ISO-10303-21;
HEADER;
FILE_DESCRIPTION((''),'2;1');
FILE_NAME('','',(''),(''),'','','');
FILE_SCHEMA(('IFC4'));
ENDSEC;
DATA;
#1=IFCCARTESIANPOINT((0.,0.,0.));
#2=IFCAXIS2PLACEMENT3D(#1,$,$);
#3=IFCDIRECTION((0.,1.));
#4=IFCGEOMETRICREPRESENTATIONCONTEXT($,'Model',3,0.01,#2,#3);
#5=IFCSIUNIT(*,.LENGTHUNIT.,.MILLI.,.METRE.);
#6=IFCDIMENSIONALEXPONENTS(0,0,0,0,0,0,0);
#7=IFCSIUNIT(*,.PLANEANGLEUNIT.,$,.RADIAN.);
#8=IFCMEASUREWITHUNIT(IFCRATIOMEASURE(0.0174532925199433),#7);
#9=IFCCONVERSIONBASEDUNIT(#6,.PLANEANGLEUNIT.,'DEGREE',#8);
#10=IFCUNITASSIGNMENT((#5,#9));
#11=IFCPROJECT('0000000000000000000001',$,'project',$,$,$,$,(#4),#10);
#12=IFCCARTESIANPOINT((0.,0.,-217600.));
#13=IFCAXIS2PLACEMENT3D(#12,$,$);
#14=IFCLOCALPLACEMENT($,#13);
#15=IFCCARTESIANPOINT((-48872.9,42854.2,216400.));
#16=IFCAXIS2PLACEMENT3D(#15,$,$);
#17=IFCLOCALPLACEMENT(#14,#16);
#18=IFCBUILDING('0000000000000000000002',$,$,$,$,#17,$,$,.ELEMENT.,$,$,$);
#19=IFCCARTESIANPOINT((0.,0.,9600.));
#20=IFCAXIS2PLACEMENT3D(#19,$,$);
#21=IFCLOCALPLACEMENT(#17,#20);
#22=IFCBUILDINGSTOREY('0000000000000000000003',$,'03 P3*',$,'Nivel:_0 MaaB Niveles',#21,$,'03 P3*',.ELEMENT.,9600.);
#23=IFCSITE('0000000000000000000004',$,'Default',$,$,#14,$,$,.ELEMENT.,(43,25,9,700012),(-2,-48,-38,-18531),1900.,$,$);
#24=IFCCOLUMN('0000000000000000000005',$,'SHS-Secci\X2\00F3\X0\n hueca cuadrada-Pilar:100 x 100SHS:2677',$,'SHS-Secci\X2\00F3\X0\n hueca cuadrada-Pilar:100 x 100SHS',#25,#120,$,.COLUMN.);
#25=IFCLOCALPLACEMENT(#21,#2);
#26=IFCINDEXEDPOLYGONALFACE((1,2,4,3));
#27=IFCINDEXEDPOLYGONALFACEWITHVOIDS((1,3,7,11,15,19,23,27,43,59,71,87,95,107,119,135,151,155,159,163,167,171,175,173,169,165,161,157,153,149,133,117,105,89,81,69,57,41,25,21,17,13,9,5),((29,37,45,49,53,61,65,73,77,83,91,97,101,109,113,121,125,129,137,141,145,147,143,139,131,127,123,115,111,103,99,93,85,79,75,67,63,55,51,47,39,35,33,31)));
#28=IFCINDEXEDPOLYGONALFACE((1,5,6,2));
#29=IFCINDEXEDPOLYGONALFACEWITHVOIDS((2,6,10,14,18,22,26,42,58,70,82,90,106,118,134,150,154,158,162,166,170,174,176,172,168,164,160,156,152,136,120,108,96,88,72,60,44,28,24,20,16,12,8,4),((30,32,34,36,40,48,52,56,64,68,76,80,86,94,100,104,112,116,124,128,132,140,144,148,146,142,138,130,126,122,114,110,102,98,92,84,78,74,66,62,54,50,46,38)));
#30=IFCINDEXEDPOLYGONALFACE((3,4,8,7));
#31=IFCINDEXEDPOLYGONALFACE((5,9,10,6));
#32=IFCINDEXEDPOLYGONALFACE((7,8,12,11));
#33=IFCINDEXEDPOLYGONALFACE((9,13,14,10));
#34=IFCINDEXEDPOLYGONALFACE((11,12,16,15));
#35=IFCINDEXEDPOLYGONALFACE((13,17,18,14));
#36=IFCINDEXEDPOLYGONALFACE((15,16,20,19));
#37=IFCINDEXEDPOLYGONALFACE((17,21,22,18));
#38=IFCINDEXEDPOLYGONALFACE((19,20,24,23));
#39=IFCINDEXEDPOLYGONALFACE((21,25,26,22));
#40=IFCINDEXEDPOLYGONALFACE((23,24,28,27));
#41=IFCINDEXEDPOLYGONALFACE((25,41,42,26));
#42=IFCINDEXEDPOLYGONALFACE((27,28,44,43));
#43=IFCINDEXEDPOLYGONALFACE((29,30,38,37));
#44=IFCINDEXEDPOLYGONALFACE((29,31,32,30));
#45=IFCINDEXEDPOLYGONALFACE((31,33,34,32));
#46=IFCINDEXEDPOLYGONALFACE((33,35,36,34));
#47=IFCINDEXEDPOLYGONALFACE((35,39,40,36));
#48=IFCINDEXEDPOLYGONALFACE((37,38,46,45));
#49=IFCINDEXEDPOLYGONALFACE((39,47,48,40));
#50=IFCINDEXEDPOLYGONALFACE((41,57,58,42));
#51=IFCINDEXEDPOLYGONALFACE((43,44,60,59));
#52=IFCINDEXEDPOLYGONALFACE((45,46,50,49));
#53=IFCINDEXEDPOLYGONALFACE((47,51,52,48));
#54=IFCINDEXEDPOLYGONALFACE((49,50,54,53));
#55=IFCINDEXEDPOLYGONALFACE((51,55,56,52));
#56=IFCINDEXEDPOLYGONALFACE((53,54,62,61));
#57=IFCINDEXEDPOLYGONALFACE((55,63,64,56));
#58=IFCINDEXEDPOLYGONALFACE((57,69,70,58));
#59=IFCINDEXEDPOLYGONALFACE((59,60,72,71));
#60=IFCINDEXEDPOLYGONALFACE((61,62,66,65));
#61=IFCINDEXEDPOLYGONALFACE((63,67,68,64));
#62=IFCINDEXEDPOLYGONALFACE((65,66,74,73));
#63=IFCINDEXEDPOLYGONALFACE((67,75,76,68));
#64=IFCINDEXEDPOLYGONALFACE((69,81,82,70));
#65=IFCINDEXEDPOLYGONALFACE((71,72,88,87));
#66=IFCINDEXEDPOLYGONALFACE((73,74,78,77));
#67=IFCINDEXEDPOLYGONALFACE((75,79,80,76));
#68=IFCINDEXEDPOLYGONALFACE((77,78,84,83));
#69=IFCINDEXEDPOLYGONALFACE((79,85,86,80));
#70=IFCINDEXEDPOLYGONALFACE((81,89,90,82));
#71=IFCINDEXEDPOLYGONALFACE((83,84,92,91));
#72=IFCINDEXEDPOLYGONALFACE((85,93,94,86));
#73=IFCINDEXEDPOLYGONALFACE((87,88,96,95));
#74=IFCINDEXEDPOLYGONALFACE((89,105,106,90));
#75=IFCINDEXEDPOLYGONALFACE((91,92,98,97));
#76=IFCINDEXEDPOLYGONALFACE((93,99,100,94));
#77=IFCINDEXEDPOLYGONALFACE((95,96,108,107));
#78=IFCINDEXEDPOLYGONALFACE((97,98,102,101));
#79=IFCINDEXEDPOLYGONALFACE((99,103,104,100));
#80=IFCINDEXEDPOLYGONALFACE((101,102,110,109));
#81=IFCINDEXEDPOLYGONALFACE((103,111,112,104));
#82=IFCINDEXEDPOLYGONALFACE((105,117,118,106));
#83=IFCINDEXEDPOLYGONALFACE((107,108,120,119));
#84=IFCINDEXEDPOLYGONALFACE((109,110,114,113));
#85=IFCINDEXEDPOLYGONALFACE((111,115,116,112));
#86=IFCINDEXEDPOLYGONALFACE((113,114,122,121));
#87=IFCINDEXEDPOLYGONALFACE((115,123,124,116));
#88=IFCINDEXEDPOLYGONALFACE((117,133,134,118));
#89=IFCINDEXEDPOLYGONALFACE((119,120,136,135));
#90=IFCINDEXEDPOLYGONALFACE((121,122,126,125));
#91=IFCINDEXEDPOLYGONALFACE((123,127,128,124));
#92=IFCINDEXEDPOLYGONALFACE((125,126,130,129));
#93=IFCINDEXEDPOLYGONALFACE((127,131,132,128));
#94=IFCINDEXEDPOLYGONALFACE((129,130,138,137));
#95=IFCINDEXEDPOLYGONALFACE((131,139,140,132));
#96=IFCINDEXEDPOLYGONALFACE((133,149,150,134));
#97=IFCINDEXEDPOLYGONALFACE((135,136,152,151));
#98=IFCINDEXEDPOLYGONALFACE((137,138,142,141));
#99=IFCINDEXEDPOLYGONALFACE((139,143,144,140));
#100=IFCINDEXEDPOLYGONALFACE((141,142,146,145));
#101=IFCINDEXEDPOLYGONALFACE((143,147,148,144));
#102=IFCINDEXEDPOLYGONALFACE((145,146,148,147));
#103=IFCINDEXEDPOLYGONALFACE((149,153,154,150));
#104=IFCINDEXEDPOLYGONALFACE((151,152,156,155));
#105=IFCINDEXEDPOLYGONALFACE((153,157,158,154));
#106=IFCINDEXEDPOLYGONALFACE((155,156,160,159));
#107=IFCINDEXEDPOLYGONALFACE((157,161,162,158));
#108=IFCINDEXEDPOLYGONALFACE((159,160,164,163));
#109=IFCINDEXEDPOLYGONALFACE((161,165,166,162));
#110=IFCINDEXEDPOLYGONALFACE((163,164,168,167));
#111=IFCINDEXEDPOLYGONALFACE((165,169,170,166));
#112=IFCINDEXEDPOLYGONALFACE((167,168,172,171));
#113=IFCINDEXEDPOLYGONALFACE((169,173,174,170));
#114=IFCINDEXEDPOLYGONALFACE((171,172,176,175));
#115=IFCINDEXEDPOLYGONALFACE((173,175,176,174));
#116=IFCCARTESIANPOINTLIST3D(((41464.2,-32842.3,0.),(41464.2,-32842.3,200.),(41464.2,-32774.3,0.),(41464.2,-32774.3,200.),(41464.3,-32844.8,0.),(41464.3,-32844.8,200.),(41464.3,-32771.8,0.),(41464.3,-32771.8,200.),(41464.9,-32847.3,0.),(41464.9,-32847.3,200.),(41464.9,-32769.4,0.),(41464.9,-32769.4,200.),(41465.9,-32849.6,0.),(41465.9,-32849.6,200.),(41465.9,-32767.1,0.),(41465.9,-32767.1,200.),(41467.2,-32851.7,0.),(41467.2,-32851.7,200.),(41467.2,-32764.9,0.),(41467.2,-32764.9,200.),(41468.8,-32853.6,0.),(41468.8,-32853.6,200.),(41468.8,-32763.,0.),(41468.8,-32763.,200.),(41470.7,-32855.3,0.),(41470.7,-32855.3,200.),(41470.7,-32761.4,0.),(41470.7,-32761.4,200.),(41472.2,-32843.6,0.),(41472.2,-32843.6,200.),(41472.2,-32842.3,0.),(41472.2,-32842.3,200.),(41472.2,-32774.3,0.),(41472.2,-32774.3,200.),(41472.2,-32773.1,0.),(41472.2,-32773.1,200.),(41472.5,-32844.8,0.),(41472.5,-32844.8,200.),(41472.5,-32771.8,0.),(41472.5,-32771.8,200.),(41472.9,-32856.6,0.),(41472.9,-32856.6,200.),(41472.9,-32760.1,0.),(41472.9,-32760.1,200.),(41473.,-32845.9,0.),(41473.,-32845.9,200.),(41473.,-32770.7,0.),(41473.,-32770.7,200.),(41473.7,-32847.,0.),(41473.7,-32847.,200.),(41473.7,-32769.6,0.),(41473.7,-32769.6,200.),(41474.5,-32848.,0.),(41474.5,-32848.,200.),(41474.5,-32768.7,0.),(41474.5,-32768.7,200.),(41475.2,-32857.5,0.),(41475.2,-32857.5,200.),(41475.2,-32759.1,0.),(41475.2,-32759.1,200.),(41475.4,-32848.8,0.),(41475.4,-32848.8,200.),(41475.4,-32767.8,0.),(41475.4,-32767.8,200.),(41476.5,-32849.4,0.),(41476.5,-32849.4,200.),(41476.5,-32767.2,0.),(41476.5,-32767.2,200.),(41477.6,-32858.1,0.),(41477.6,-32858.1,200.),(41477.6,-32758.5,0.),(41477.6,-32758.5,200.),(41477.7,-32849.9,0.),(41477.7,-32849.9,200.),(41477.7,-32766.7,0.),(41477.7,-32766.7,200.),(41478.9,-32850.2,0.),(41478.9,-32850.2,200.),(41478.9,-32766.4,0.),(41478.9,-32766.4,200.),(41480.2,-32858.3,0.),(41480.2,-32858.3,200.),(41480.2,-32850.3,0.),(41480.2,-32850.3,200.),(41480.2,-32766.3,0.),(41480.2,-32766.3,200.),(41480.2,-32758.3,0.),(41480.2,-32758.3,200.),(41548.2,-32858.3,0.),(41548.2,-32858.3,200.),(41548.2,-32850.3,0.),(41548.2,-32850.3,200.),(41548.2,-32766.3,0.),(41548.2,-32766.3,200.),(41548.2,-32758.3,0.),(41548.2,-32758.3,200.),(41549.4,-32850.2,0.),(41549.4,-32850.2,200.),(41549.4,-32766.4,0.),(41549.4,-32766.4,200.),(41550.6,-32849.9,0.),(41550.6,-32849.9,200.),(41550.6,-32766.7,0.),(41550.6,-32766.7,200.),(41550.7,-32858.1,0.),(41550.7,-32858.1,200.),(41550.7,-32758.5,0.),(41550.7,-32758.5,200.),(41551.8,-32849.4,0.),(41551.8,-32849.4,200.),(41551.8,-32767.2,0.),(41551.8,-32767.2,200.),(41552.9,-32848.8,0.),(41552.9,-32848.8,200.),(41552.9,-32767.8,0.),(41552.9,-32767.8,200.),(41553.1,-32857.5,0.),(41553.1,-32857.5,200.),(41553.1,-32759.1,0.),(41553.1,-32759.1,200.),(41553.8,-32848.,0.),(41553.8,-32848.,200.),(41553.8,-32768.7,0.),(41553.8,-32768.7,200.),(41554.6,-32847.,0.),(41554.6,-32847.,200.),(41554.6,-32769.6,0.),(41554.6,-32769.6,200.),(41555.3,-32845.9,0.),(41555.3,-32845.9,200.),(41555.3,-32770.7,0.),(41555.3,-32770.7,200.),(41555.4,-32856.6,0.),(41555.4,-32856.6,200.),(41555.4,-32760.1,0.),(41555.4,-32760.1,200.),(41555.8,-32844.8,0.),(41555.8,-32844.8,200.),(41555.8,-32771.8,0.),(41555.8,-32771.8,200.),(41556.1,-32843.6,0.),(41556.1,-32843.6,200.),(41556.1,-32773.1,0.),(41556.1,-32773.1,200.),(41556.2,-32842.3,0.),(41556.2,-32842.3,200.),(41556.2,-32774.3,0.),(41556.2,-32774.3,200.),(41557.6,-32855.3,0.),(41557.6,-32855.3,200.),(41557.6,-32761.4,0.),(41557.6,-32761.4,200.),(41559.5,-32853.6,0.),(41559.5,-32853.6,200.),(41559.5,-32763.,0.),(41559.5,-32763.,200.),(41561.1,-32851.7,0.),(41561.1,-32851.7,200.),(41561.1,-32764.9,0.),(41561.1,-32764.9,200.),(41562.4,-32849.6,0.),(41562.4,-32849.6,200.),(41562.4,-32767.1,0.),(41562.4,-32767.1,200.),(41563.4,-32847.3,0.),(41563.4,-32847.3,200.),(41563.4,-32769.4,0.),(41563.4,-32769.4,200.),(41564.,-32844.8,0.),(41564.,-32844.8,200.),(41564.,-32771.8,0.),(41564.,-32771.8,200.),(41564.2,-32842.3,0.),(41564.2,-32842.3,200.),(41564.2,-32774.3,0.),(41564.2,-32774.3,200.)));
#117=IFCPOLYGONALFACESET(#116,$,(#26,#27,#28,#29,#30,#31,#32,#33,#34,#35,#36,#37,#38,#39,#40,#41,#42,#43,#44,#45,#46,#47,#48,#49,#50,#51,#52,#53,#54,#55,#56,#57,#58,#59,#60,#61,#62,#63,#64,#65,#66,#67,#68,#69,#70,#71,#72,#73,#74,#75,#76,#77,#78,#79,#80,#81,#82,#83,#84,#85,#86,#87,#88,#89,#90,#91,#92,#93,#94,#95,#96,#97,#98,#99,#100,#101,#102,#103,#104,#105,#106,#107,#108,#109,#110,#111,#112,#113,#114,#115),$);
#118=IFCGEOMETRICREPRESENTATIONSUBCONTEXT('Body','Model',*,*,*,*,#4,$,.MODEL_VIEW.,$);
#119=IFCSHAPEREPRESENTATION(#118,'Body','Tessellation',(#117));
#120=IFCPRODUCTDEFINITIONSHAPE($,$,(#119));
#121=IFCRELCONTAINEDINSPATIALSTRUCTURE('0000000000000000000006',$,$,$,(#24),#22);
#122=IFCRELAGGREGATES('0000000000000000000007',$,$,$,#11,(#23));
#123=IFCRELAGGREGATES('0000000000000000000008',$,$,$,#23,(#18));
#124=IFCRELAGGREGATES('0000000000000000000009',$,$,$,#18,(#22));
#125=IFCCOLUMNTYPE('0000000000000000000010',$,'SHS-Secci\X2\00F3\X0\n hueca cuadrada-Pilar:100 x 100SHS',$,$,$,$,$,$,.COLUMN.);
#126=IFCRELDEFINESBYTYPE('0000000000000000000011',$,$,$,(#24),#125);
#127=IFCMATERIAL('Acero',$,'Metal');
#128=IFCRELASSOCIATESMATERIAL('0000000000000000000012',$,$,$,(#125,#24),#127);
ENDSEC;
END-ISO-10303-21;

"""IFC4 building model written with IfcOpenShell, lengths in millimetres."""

from ifc_helpers import new_model, entity, si_unit, converted_unit, direction, frame, origin, place, context, subcontext, project, spatial, indexed_curve, outline, extrude, source, transform, mapped, material, type_object, type_shapes, element, save


model = new_model("IFC4")

# Units and contexts
model_context = context("Model", 3, precision=0.01, world=origin(), true_north=direction((0.0, 1.0)))
body_context = subcontext(model_context, "Body", "Model", "MODEL_VIEW")
ifc_project = project(units=[si_unit("LENGTHUNIT", "METRE", prefix="MILLI"), converted_unit("PLANEANGLEUNIT", "DEGREE", entity("IfcRatioMeasure", 0.0174532925199433), si_unit("PLANEANGLEUNIT", "RADIAN"), dimensions=[0, 0, 0, 0, 0, 0, 0])], contexts=[model_context])

# Site, building, storey
site_placement = place(None, frame((0.0, 0.0, -217600.0)))
site = spatial("IfcSite", under=ifc_project, at=site_placement, Name="Default", CompositionType="ELEMENT", RefLatitude=(43, 25, 9, 700012), RefLongitude=(-2, -48, -38, -18531), RefElevation=1900.0)
building_placement = place(site_placement, frame((-48872.9, 42854.2, 216400.0)))
building = spatial("IfcBuilding", under=site, at=building_placement, CompositionType="ELEMENT")
storey_placement = place(building_placement, frame((0.0, 0.0, 9600.0)))
storey = spatial("IfcBuildingStorey", under=building, at=storey_placement, Name="03 P3*", ObjectType="Nivel:_0 MaaB Niveles", LongName="03 P3*", CompositionType="ELEMENT", Elevation=9600.0)

# Column
ifc_material_1 = material(Name="Acero", Category="Metal")
column_type_1 = type_object("IfcColumnType", Name="SHS-Sección hueca cuadrada-Pilar:100 x 100SHS", PredefinedType="COLUMN", material=ifc_material_1)
shared_shape_1 = source(origin(), body_context, "Body", "SweptSolid", [
    extrude(outline(indexed_curve([(-34.0, -50.0), (34.0, -50.0), (36.5, -49.8), (38.9, -49.2), (41.3, -48.3), (43.4, -46.9), (45.3, -45.3), (46.9, -43.4), (48.3, -41.3), (49.2, -38.9), (49.8, -36.5), (50.0, -34.0), (50.0, 34.0), (49.8, 36.5), (49.2, 38.9), (48.3, 41.3), (46.9, 43.4), (45.3, 45.3), (43.4, 46.9), (41.3, 48.3), (38.9, 49.2), (36.5, 49.8), (34.0, 50.0), (-34.0, 50.0), (-36.5, 49.8), (-38.9, 49.2), (-41.3, 48.3), (-43.4, 46.9), (-45.3, 45.3), (-46.9, 43.4), (-48.3, 41.3), (-49.2, 38.9), (-49.8, 36.5), (-50.0, 34.0), (-50.0, -34.0), (-49.8, -36.5), (-49.2, -38.9), (-48.3, -41.3), (-46.9, -43.4), (-45.3, -45.3), (-43.4, -46.9), (-41.3, -48.3), (-38.9, -49.2), (-36.5, -49.8), (-34.0, -50.0)], self_intersect=False), holes=[indexed_curve([(-42.0, 34.0), (-41.9, 35.3), (-41.6, 36.5), (-41.1, 37.6), (-40.5, 38.7), (-39.7, 39.7), (-38.7, 40.5), (-37.6, 41.1), (-36.5, 41.6), (-35.3, 41.9), (-34.0, 42.0), (34.0, 42.0), (35.3, 41.9), (36.5, 41.6), (37.6, 41.1), (38.7, 40.5), (39.7, 39.7), (40.5, 38.7), (41.1, 37.6), (41.6, 36.5), (41.9, 35.3), (42.0, 34.0), (42.0, -34.0), (41.9, -35.3), (41.6, -36.5), (41.1, -37.6), (40.5, -38.7), (39.7, -39.7), (38.7, -40.5), (37.6, -41.1), (36.5, -41.6), (35.3, -41.9), (34.0, -42.0), (-34.0, -42.0), (-35.3, -41.9), (-36.5, -41.6), (-37.6, -41.1), (-38.7, -40.5), (-39.7, -39.7), (-40.5, -38.7), (-41.1, -37.6), (-41.6, -36.5), (-41.9, -35.3), (-42.0, -34.0), (-42.0, 34.0)], self_intersect=False)]), frame((0.0, 0.0, 9600.0), z_axis=(0.0, 0.0, 1.0), x_axis=(0.0, 1.0, 0.0)), (0.0, 0.0, 1.0), 200.0),
])
type_shapes(column_type_1, [shared_shape_1])
column_1_placement = place(storey_placement, frame((41514.2, -32808.3, -9600.0), z_axis=(0.0, 0.0, 1.0), x_axis=(0.0, -1.0, 0.0)))
element("IfcColumn", 1, at=column_1_placement, inside=storey, type_object=column_type_1, material=ifc_material_1, Name="SHS-Sección hueca cuadrada-Pilar:100 x 100SHS:2677", ObjectType="SHS-Sección hueca cuadrada-Pilar:100 x 100SHS", PredefinedType="COLUMN", context=body_context, shape_type="MappedRepresentation", body=[
    mapped(shared_shape_1, transform((0.0, 0.0, 0.0), scale=1.0)),
])

save(model, "model.ifc")
